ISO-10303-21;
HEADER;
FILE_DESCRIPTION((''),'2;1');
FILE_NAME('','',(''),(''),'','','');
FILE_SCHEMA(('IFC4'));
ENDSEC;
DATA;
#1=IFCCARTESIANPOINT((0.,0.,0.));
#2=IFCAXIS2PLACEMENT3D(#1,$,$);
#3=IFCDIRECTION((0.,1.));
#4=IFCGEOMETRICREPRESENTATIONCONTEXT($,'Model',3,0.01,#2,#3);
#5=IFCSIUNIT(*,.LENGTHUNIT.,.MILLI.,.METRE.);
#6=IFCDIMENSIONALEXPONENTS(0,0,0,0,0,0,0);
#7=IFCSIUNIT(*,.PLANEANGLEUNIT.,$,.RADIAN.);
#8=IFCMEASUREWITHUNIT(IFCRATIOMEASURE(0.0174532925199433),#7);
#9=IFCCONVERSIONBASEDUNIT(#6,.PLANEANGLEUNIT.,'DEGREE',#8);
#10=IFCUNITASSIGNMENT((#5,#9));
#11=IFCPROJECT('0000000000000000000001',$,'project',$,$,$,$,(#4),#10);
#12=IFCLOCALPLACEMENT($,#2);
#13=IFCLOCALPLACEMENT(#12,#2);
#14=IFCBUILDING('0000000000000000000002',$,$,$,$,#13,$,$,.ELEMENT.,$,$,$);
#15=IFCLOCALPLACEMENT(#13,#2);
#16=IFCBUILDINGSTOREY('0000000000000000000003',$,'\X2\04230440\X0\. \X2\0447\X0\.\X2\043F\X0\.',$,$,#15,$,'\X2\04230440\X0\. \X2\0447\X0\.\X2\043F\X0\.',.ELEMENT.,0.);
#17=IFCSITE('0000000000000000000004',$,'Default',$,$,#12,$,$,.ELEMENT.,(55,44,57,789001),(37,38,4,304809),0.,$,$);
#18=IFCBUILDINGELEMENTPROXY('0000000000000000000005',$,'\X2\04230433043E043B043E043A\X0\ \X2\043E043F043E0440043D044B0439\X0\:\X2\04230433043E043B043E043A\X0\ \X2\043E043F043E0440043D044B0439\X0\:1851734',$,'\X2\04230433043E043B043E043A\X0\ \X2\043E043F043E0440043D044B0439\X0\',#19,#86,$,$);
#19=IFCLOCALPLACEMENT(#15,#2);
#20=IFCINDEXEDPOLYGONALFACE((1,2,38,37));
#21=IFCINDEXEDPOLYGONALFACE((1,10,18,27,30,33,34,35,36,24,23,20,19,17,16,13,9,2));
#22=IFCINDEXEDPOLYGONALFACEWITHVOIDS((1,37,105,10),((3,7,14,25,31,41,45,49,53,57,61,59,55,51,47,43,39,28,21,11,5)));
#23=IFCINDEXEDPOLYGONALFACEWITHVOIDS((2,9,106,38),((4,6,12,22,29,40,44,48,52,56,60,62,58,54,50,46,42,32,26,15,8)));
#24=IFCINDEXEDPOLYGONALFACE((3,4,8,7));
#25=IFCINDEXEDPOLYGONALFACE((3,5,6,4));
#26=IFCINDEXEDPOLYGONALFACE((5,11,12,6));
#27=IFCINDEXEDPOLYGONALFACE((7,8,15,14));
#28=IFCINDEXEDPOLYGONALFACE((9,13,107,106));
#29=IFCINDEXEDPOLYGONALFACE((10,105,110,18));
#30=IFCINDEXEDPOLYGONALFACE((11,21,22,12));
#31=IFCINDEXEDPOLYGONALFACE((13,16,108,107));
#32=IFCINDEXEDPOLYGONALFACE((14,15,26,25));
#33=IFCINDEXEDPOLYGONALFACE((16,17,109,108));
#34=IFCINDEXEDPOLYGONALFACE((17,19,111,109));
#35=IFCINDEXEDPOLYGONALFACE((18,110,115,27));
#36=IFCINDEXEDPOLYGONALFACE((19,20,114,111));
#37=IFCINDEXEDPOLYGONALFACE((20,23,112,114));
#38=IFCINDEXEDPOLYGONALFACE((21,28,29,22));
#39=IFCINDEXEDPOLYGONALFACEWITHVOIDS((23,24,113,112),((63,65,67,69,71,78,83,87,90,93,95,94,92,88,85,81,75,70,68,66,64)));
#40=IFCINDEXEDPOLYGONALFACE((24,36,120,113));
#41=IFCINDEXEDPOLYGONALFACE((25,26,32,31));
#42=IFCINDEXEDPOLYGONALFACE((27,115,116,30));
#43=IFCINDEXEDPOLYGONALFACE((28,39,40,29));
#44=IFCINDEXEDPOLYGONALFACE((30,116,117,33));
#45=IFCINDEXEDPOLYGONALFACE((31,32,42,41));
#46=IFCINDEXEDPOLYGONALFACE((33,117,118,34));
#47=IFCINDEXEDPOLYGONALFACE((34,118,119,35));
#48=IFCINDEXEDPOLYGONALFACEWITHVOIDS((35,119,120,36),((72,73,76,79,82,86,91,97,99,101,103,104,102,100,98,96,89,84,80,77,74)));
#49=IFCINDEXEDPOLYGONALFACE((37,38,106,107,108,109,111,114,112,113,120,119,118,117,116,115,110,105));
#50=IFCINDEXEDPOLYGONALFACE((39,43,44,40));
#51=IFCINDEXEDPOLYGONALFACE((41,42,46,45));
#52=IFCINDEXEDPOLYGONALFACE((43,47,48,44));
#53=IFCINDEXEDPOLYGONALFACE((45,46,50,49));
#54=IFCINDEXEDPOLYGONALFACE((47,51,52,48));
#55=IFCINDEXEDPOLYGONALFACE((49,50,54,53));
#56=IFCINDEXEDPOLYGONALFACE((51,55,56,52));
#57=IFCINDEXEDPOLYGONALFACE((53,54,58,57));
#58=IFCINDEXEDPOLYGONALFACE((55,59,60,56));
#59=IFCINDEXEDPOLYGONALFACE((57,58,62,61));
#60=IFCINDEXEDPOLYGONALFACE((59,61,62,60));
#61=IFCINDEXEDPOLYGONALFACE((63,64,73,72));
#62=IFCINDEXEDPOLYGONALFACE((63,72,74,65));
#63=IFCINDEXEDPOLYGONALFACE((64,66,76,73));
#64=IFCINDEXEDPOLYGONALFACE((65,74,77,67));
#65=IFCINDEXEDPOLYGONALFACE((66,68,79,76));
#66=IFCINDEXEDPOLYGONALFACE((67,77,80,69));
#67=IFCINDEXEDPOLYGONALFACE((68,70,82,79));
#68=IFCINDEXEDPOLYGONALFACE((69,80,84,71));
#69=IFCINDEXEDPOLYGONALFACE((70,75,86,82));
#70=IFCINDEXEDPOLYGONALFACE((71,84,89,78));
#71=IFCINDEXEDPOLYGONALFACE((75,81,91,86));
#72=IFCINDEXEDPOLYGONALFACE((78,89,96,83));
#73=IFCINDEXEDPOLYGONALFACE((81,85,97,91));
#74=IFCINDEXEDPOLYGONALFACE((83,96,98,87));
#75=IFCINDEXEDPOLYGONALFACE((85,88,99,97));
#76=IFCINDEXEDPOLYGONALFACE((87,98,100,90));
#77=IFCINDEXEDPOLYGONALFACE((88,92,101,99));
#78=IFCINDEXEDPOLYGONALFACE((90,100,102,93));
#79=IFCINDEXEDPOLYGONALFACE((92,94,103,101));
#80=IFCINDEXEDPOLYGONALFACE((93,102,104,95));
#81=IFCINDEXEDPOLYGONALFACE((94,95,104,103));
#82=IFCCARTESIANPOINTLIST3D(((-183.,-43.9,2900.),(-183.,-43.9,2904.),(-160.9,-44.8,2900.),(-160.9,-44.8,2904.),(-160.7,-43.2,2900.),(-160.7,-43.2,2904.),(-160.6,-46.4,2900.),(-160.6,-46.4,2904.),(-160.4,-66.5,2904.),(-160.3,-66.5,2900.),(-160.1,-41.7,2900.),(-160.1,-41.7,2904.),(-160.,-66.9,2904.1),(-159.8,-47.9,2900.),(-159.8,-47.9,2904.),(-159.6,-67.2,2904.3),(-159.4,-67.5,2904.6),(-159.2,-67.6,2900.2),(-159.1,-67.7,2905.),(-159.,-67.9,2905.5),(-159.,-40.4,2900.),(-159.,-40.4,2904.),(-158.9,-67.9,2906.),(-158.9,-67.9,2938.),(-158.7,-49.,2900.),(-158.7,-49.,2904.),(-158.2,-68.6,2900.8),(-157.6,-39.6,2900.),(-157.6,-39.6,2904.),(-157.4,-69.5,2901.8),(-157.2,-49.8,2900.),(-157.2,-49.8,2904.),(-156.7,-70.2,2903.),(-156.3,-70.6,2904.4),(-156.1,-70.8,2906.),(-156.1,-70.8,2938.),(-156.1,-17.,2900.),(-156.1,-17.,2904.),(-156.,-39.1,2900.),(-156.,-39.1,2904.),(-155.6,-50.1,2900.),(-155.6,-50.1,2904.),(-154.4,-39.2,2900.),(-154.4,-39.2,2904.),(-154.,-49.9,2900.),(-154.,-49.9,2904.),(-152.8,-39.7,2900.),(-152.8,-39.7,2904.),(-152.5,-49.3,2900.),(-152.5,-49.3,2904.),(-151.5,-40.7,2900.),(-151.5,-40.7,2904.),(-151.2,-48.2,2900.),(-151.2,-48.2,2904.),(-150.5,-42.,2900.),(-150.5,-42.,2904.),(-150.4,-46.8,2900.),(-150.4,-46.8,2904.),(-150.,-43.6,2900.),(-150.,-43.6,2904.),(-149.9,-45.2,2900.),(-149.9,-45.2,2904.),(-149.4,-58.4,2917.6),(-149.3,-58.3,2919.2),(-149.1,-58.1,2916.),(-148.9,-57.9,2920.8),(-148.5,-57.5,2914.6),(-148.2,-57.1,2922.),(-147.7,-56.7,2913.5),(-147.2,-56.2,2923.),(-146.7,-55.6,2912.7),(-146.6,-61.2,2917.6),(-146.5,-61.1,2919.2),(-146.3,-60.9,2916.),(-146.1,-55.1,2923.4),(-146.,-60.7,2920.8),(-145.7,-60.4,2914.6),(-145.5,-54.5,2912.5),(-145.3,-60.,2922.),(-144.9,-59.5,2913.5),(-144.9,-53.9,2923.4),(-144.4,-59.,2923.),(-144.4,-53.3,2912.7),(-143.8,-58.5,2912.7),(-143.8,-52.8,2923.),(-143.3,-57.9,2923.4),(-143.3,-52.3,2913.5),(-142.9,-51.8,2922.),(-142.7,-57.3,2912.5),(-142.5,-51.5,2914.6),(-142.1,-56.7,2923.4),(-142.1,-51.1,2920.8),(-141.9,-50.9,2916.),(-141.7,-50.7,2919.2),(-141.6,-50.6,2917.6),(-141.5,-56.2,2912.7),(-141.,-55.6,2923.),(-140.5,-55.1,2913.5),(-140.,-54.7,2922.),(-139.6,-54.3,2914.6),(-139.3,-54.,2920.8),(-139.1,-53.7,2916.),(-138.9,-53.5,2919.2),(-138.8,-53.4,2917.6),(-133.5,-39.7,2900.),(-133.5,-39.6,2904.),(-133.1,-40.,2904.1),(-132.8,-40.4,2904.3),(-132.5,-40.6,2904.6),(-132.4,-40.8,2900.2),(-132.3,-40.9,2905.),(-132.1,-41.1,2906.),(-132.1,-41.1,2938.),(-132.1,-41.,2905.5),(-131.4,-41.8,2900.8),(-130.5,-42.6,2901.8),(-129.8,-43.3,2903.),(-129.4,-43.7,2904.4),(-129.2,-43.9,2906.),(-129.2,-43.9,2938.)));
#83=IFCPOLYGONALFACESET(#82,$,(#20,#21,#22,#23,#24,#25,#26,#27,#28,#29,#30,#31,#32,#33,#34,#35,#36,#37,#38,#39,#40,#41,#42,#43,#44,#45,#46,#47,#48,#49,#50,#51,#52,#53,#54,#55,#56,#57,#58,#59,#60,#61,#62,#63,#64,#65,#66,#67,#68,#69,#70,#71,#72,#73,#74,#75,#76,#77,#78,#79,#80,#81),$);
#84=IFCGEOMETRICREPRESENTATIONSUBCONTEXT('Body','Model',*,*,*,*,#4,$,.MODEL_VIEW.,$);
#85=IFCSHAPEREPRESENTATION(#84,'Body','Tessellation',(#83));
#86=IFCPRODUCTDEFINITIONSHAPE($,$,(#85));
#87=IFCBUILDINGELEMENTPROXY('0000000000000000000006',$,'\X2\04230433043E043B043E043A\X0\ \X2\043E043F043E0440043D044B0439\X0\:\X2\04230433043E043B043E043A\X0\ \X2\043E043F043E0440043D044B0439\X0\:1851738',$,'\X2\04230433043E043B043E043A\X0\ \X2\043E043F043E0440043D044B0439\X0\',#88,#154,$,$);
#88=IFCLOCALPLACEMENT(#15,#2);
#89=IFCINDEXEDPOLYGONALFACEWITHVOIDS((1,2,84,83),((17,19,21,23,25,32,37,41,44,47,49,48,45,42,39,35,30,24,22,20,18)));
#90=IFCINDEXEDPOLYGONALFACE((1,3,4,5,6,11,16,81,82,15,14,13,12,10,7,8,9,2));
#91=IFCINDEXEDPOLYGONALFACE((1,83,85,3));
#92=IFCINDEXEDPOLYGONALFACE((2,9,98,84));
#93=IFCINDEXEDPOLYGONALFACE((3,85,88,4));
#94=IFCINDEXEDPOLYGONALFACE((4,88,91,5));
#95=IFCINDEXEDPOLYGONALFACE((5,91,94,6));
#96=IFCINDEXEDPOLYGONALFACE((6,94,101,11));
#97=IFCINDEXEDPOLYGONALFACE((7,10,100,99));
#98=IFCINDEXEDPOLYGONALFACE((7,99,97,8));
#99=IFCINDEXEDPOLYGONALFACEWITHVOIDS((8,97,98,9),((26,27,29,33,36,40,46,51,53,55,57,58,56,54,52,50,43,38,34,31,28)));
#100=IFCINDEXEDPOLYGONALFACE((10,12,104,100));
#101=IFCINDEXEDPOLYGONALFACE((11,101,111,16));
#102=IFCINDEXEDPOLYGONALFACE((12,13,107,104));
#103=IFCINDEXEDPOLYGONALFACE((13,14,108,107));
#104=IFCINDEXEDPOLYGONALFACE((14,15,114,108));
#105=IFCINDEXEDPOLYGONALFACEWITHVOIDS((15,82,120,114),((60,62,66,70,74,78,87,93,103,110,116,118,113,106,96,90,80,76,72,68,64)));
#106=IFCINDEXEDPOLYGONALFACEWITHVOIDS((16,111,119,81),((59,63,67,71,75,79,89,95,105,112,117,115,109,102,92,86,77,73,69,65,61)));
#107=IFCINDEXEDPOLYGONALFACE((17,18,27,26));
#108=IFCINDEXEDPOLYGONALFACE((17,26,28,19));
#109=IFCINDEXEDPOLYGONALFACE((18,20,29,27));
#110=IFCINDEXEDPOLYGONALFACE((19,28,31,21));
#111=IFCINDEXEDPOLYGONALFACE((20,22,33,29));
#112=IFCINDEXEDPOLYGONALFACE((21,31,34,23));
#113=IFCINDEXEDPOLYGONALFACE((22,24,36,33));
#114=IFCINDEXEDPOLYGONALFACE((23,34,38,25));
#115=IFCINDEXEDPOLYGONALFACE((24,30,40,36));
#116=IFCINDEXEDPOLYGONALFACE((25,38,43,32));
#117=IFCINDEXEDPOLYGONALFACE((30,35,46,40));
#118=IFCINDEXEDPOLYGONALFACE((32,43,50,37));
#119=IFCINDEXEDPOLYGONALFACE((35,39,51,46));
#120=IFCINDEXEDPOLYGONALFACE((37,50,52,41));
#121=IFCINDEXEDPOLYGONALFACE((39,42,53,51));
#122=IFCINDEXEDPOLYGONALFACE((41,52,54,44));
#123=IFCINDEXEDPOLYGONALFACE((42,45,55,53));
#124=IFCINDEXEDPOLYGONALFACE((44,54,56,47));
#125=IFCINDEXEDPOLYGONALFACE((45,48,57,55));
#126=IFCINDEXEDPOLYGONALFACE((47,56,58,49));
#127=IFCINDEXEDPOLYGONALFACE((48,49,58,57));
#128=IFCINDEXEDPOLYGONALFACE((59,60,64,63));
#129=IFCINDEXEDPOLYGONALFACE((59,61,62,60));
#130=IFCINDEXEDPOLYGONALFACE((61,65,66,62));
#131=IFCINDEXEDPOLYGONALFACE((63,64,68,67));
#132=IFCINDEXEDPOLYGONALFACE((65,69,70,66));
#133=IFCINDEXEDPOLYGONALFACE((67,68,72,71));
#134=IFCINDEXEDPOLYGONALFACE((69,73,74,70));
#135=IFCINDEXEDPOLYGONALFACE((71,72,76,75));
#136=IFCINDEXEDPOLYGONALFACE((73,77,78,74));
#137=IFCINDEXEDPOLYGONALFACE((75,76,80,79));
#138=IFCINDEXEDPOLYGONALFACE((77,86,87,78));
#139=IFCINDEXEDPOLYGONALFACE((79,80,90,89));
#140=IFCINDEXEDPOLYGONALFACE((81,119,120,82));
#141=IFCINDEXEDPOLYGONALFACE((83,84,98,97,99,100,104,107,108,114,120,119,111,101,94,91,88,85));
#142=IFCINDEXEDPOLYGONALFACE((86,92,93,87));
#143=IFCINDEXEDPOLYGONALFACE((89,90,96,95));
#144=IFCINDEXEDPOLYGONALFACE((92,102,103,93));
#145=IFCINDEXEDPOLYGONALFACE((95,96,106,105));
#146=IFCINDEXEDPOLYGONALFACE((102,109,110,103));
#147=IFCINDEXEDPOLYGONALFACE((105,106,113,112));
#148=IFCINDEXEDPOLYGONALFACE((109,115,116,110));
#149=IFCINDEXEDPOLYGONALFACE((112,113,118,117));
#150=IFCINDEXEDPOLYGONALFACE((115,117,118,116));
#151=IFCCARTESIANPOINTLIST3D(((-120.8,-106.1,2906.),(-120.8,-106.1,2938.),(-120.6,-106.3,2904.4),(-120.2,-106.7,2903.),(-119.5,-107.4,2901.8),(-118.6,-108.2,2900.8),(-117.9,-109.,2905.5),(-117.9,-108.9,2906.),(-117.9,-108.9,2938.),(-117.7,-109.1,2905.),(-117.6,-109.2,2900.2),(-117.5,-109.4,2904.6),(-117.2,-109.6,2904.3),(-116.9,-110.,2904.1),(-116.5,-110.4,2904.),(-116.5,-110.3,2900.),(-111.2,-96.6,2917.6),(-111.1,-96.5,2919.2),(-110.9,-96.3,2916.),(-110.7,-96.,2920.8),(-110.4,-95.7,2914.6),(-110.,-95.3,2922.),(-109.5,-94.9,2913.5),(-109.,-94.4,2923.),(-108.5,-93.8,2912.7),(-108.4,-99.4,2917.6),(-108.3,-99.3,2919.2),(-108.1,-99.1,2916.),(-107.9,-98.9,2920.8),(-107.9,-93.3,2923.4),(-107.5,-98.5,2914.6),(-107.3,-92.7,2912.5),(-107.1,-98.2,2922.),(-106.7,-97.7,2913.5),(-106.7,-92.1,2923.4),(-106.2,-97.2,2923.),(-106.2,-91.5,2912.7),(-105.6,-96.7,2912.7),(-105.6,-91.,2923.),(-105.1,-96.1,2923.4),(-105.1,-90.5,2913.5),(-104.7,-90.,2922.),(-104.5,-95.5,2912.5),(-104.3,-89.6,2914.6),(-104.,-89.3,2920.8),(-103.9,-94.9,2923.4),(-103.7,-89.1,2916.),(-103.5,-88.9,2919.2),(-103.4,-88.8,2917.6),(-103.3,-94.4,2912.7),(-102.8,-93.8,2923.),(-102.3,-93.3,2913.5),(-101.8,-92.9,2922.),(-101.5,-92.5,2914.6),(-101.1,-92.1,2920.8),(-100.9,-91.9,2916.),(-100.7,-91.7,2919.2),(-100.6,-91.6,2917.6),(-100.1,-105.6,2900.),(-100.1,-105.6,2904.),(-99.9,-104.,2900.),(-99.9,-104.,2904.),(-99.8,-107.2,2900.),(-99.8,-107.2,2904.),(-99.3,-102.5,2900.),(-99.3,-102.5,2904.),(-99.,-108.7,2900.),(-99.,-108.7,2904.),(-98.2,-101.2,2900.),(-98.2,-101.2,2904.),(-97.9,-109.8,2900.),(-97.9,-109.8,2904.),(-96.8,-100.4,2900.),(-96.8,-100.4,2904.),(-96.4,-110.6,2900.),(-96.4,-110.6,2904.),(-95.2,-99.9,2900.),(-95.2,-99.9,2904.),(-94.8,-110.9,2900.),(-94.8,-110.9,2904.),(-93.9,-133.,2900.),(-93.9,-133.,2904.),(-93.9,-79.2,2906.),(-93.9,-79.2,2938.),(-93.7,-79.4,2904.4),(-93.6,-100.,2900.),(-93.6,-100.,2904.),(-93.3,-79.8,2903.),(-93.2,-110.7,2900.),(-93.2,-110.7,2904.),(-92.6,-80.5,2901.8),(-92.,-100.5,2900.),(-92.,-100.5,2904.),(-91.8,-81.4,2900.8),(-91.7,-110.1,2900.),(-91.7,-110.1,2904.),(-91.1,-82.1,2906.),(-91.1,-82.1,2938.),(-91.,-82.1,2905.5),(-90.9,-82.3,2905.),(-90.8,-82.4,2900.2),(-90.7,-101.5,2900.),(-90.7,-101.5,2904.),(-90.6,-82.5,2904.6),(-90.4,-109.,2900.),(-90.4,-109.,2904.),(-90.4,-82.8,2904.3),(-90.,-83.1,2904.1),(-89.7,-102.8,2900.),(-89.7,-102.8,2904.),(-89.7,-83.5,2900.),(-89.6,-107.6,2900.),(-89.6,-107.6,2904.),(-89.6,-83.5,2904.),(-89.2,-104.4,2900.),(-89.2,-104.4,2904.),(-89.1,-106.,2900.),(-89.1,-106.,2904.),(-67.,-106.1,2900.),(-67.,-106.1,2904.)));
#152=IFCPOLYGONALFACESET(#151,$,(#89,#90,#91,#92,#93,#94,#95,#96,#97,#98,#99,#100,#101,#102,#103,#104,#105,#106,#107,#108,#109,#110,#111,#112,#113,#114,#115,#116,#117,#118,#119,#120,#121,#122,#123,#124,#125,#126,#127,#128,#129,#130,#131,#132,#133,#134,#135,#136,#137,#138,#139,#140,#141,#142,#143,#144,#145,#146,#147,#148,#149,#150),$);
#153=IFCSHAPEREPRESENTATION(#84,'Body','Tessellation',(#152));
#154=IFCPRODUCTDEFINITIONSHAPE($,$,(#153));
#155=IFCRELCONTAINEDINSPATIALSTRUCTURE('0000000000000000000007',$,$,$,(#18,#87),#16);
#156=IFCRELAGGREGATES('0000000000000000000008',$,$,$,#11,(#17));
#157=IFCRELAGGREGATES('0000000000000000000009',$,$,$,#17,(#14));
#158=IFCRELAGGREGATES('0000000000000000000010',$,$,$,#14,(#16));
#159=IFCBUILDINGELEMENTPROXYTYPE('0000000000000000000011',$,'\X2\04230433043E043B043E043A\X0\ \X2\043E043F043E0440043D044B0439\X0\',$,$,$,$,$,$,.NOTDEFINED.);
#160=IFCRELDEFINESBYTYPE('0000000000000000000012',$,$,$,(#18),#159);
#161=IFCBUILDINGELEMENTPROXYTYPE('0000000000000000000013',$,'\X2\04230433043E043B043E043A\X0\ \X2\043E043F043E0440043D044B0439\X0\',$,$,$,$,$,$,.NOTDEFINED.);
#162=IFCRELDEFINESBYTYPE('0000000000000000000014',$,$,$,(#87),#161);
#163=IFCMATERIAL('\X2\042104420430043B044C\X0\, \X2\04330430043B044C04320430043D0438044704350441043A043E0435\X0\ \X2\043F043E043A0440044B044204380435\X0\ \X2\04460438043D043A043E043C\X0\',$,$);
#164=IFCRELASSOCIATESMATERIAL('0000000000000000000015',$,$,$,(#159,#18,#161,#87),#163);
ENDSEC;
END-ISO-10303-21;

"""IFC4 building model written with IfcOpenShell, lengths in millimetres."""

from ifc_helpers import new_model, entity, si_unit, converted_unit, direction, frame, frame_2d, origin, place, context, subcontext, project, spatial, polyline, circle_curve, parameter, trimmed, segment, composite_curve, circle, outline, extrude, source, transform, mapped, material, type_object, type_shapes, element, save


model = new_model("IFC4")

# Units and contexts
model_context = context("Model", 3, precision=0.01, world=origin(), true_north=direction((0.0, 1.0)))
body_context = subcontext(model_context, "Body", "Model", "MODEL_VIEW")
ifc_project = project(units=[si_unit("LENGTHUNIT", "METRE", prefix="MILLI"), converted_unit("PLANEANGLEUNIT", "DEGREE", entity("IfcRatioMeasure", 0.0174532925199433), si_unit("PLANEANGLEUNIT", "RADIAN"), dimensions=[0, 0, 0, 0, 0, 0, 0])], contexts=[model_context])

# Site, building, storey
site_placement = place(None, origin())
site = spatial("IfcSite", under=ifc_project, at=site_placement, Name="Default", CompositionType="ELEMENT", RefLatitude=(55, 44, 57, 789001), RefLongitude=(37, 38, 4, 304809), RefElevation=0.0)
building_placement = place(site_placement, origin())
building = spatial("IfcBuilding", under=site, at=building_placement, CompositionType="ELEMENT")
storey_placement = place(building_placement, origin())
storey = spatial("IfcBuildingStorey", under=building, at=storey_placement, Name="Ур. ч.п.", LongName="Ур. ч.п.", CompositionType="ELEMENT", Elevation=0.0)

# Building element proxies, openings
ifc_material_1 = material(Name="Сталь, гальваническое покрытие цинком")
building_element_proxy_type_1 = type_object("IfcBuildingElementProxyType", Name="Уголок опорный", material=ifc_material_1)
shared_shape_1 = source(origin(), body_context, "Body", "SweptSolid", [
    extrude(outline(composite_curve([segment(polyline([(-6.0, -12.0), (26.0, -12.0)]), True, "CONTINUOUS"), segment(polyline([(26.0, -12.0), (26.0, -8.0)]), True, "CONTINUOUS"), segment(polyline([(26.0, -8.0), (-6.0, -8.0)]), True, "CONTINUOUS"), segment(trimmed(circle_curve(frame_2d((-6.0, -6.0), x_axis=(0.0, -1.0)), 2.0), [parameter(270.0)], [parameter(0.0)], True, "PARAMETER"), False, "CONTINUOUS"), segment(polyline([(-8.0, -6.0), (-8.0, 26.0)]), True, "CONTINUOUS"), segment(polyline([(-8.0, 26.0), (-12.0, 26.0)]), True, "CONTINUOUS"), segment(polyline([(-12.0, 26.0), (-12.0, -6.0)]), True, "CONTINUOUS"), segment(trimmed(circle_curve(frame_2d((-6.0, -6.0), x_axis=(0.0, -1.0)), 6.0), [parameter(270.0)], [parameter(360.0)], True, "PARAMETER"), True, "CONTINUOUS")], self_intersect=False)), frame((12.0, -19.0, 12.0), z_axis=(0.0, 1.0, 0.0), x_axis=(0.0, 0.0, 1.0)), (0.0, 0.0, 1.0), 38.0),
])
type_shapes(building_element_proxy_type_1, [shared_shape_1])
proxy_1_placement = place(storey_placement, frame((-142.7, -57.3, 2900.0), z_axis=(0.0, 0.0, 1.0), x_axis=(-0.707107, 0.707107, 0.0)))
proxy_1 = element("IfcBuildingElementProxy", 1, at=proxy_1_placement, inside=storey, type_object=building_element_proxy_type_1, material=ifc_material_1, Name="Уголок опорный:Уголок опорный:1851734", ObjectType="Уголок опорный", context=body_context, shape_type="MappedRepresentation", body=[
    mapped(shared_shape_1, transform((0.0, 0.0, 0.0), scale=1.0)),
])
opening_1_placement = place(storey_placement, frame((-142.7, -57.3, 2900.0), z_axis=(0.0, 0.0, 1.0), x_axis=(0.0, -1.0, 0.0)))
element("IfcOpeningElement", 2, at=opening_1_placement, cuts=proxy_1, ObjectType="Opening", PredefinedType="OPENING", context=body_context, shape_type="SweptSolid", body=[
    extrude(circle(Radius=5.5, at=frame_2d((0.0, 0.0), x_axis=(1.0, 0.0))), frame((-2.8, -2.8, 18.0), z_axis=(0.707107, 0.707107, 0.0), x_axis=(0.0, 0.0, -1.0)), (0.0, 0.0, 1.0), 4.0),
])
opening_2_placement = place(storey_placement, frame((-142.7, -57.3, 2900.0), z_axis=(0.0, 0.0, 1.0), x_axis=(0.0, -1.0, 0.0)))
element("IfcOpeningElement", 3, at=opening_2_placement, cuts=proxy_1, ObjectType="Opening", PredefinedType="OPENING", context=body_context, shape_type="SweptSolid", body=[
    extrude(circle(Radius=5.5, at=frame_2d((0.0, 0.0), x_axis=(1.0, 0.0))), frame((-12.7, -12.7, 0.0), z_axis=(0.0, 0.0, 1.0), x_axis=(-0.707107, 0.707107, 0.0)), (0.0, 0.0, 1.0), 4.0),
])
building_element_proxy_type_2 = type_object("IfcBuildingElementProxyType", Name="Уголок опорный", material=ifc_material_1)
shared_shape_2 = source(origin(), body_context, "Body", "SweptSolid", [
    extrude(outline(composite_curve([segment(polyline([(-6.0, -12.0), (26.0, -12.0)]), True, "CONTINUOUS"), segment(polyline([(26.0, -12.0), (26.0, -8.0)]), True, "CONTINUOUS"), segment(polyline([(26.0, -8.0), (-6.0, -8.0)]), True, "CONTINUOUS"), segment(trimmed(circle_curve(frame_2d((-6.0, -6.0), x_axis=(0.0, -1.0)), 2.0), [parameter(270.0)], [parameter(0.0)], True, "PARAMETER"), False, "CONTINUOUS"), segment(polyline([(-8.0, -6.0), (-8.0, 26.0)]), True, "CONTINUOUS"), segment(polyline([(-8.0, 26.0), (-12.0, 26.0)]), True, "CONTINUOUS"), segment(polyline([(-12.0, 26.0), (-12.0, -6.0)]), True, "CONTINUOUS"), segment(trimmed(circle_curve(frame_2d((-6.0, -6.0), x_axis=(0.0, -1.0)), 6.0), [parameter(270.0)], [parameter(360.0)], True, "PARAMETER"), True, "CONTINUOUS")], self_intersect=False)), frame((12.0, -19.0, 12.0), z_axis=(0.0, 1.0, 0.0), x_axis=(0.0, 0.0, 1.0)), (0.0, 0.0, 1.0), 38.0),
])
type_shapes(building_element_proxy_type_2, [shared_shape_2])
proxy_2_placement = place(storey_placement, frame((-107.3, -92.7, 2900.0), z_axis=(0.0, 0.0, 1.0), x_axis=(0.707107, -0.707107, 0.0)))
proxy_2 = element("IfcBuildingElementProxy", 4, at=proxy_2_placement, inside=storey, type_object=building_element_proxy_type_2, material=ifc_material_1, Name="Уголок опорный:Уголок опорный:1851738", ObjectType="Уголок опорный", context=body_context, shape_type="MappedRepresentation", body=[
    mapped(shared_shape_2, transform((0.0, 0.0, 0.0), scale=1.0)),
])
opening_3_placement = place(storey_placement, frame((-107.3, -92.7, 2900.0), z_axis=(0.0, 0.0, 1.0), x_axis=(0.0, -1.0, 0.0)))
element("IfcOpeningElement", 5, at=opening_3_placement, cuts=proxy_2, ObjectType="Opening", PredefinedType="OPENING", context=body_context, shape_type="SweptSolid", body=[
    extrude(circle(Radius=5.5, at=frame_2d((0.0, 0.0), x_axis=(1.0, 0.0))), frame((2.8, 2.8, 18.0), z_axis=(-0.707107, -0.707107, 0.0), x_axis=(0.0, 0.0, -1.0)), (0.0, 0.0, 1.0), 4.0),
])
opening_4_placement = place(storey_placement, frame((-107.3, -92.7, 2900.0), z_axis=(0.0, 0.0, 1.0), x_axis=(0.0, -1.0, 0.0)))
element("IfcOpeningElement", 6, at=opening_4_placement, cuts=proxy_2, ObjectType="Opening", PredefinedType="OPENING", context=body_context, shape_type="SweptSolid", body=[
    extrude(circle(Radius=5.5, at=frame_2d((0.0, 0.0), x_axis=(1.0, 0.0))), frame((12.7, 12.7, 0.0), z_axis=(0.0, 0.0, 1.0), x_axis=(-0.707107, 0.707107, 0.0)), (0.0, 0.0, 1.0), 4.0),
])

save(model, "model.ifc")
